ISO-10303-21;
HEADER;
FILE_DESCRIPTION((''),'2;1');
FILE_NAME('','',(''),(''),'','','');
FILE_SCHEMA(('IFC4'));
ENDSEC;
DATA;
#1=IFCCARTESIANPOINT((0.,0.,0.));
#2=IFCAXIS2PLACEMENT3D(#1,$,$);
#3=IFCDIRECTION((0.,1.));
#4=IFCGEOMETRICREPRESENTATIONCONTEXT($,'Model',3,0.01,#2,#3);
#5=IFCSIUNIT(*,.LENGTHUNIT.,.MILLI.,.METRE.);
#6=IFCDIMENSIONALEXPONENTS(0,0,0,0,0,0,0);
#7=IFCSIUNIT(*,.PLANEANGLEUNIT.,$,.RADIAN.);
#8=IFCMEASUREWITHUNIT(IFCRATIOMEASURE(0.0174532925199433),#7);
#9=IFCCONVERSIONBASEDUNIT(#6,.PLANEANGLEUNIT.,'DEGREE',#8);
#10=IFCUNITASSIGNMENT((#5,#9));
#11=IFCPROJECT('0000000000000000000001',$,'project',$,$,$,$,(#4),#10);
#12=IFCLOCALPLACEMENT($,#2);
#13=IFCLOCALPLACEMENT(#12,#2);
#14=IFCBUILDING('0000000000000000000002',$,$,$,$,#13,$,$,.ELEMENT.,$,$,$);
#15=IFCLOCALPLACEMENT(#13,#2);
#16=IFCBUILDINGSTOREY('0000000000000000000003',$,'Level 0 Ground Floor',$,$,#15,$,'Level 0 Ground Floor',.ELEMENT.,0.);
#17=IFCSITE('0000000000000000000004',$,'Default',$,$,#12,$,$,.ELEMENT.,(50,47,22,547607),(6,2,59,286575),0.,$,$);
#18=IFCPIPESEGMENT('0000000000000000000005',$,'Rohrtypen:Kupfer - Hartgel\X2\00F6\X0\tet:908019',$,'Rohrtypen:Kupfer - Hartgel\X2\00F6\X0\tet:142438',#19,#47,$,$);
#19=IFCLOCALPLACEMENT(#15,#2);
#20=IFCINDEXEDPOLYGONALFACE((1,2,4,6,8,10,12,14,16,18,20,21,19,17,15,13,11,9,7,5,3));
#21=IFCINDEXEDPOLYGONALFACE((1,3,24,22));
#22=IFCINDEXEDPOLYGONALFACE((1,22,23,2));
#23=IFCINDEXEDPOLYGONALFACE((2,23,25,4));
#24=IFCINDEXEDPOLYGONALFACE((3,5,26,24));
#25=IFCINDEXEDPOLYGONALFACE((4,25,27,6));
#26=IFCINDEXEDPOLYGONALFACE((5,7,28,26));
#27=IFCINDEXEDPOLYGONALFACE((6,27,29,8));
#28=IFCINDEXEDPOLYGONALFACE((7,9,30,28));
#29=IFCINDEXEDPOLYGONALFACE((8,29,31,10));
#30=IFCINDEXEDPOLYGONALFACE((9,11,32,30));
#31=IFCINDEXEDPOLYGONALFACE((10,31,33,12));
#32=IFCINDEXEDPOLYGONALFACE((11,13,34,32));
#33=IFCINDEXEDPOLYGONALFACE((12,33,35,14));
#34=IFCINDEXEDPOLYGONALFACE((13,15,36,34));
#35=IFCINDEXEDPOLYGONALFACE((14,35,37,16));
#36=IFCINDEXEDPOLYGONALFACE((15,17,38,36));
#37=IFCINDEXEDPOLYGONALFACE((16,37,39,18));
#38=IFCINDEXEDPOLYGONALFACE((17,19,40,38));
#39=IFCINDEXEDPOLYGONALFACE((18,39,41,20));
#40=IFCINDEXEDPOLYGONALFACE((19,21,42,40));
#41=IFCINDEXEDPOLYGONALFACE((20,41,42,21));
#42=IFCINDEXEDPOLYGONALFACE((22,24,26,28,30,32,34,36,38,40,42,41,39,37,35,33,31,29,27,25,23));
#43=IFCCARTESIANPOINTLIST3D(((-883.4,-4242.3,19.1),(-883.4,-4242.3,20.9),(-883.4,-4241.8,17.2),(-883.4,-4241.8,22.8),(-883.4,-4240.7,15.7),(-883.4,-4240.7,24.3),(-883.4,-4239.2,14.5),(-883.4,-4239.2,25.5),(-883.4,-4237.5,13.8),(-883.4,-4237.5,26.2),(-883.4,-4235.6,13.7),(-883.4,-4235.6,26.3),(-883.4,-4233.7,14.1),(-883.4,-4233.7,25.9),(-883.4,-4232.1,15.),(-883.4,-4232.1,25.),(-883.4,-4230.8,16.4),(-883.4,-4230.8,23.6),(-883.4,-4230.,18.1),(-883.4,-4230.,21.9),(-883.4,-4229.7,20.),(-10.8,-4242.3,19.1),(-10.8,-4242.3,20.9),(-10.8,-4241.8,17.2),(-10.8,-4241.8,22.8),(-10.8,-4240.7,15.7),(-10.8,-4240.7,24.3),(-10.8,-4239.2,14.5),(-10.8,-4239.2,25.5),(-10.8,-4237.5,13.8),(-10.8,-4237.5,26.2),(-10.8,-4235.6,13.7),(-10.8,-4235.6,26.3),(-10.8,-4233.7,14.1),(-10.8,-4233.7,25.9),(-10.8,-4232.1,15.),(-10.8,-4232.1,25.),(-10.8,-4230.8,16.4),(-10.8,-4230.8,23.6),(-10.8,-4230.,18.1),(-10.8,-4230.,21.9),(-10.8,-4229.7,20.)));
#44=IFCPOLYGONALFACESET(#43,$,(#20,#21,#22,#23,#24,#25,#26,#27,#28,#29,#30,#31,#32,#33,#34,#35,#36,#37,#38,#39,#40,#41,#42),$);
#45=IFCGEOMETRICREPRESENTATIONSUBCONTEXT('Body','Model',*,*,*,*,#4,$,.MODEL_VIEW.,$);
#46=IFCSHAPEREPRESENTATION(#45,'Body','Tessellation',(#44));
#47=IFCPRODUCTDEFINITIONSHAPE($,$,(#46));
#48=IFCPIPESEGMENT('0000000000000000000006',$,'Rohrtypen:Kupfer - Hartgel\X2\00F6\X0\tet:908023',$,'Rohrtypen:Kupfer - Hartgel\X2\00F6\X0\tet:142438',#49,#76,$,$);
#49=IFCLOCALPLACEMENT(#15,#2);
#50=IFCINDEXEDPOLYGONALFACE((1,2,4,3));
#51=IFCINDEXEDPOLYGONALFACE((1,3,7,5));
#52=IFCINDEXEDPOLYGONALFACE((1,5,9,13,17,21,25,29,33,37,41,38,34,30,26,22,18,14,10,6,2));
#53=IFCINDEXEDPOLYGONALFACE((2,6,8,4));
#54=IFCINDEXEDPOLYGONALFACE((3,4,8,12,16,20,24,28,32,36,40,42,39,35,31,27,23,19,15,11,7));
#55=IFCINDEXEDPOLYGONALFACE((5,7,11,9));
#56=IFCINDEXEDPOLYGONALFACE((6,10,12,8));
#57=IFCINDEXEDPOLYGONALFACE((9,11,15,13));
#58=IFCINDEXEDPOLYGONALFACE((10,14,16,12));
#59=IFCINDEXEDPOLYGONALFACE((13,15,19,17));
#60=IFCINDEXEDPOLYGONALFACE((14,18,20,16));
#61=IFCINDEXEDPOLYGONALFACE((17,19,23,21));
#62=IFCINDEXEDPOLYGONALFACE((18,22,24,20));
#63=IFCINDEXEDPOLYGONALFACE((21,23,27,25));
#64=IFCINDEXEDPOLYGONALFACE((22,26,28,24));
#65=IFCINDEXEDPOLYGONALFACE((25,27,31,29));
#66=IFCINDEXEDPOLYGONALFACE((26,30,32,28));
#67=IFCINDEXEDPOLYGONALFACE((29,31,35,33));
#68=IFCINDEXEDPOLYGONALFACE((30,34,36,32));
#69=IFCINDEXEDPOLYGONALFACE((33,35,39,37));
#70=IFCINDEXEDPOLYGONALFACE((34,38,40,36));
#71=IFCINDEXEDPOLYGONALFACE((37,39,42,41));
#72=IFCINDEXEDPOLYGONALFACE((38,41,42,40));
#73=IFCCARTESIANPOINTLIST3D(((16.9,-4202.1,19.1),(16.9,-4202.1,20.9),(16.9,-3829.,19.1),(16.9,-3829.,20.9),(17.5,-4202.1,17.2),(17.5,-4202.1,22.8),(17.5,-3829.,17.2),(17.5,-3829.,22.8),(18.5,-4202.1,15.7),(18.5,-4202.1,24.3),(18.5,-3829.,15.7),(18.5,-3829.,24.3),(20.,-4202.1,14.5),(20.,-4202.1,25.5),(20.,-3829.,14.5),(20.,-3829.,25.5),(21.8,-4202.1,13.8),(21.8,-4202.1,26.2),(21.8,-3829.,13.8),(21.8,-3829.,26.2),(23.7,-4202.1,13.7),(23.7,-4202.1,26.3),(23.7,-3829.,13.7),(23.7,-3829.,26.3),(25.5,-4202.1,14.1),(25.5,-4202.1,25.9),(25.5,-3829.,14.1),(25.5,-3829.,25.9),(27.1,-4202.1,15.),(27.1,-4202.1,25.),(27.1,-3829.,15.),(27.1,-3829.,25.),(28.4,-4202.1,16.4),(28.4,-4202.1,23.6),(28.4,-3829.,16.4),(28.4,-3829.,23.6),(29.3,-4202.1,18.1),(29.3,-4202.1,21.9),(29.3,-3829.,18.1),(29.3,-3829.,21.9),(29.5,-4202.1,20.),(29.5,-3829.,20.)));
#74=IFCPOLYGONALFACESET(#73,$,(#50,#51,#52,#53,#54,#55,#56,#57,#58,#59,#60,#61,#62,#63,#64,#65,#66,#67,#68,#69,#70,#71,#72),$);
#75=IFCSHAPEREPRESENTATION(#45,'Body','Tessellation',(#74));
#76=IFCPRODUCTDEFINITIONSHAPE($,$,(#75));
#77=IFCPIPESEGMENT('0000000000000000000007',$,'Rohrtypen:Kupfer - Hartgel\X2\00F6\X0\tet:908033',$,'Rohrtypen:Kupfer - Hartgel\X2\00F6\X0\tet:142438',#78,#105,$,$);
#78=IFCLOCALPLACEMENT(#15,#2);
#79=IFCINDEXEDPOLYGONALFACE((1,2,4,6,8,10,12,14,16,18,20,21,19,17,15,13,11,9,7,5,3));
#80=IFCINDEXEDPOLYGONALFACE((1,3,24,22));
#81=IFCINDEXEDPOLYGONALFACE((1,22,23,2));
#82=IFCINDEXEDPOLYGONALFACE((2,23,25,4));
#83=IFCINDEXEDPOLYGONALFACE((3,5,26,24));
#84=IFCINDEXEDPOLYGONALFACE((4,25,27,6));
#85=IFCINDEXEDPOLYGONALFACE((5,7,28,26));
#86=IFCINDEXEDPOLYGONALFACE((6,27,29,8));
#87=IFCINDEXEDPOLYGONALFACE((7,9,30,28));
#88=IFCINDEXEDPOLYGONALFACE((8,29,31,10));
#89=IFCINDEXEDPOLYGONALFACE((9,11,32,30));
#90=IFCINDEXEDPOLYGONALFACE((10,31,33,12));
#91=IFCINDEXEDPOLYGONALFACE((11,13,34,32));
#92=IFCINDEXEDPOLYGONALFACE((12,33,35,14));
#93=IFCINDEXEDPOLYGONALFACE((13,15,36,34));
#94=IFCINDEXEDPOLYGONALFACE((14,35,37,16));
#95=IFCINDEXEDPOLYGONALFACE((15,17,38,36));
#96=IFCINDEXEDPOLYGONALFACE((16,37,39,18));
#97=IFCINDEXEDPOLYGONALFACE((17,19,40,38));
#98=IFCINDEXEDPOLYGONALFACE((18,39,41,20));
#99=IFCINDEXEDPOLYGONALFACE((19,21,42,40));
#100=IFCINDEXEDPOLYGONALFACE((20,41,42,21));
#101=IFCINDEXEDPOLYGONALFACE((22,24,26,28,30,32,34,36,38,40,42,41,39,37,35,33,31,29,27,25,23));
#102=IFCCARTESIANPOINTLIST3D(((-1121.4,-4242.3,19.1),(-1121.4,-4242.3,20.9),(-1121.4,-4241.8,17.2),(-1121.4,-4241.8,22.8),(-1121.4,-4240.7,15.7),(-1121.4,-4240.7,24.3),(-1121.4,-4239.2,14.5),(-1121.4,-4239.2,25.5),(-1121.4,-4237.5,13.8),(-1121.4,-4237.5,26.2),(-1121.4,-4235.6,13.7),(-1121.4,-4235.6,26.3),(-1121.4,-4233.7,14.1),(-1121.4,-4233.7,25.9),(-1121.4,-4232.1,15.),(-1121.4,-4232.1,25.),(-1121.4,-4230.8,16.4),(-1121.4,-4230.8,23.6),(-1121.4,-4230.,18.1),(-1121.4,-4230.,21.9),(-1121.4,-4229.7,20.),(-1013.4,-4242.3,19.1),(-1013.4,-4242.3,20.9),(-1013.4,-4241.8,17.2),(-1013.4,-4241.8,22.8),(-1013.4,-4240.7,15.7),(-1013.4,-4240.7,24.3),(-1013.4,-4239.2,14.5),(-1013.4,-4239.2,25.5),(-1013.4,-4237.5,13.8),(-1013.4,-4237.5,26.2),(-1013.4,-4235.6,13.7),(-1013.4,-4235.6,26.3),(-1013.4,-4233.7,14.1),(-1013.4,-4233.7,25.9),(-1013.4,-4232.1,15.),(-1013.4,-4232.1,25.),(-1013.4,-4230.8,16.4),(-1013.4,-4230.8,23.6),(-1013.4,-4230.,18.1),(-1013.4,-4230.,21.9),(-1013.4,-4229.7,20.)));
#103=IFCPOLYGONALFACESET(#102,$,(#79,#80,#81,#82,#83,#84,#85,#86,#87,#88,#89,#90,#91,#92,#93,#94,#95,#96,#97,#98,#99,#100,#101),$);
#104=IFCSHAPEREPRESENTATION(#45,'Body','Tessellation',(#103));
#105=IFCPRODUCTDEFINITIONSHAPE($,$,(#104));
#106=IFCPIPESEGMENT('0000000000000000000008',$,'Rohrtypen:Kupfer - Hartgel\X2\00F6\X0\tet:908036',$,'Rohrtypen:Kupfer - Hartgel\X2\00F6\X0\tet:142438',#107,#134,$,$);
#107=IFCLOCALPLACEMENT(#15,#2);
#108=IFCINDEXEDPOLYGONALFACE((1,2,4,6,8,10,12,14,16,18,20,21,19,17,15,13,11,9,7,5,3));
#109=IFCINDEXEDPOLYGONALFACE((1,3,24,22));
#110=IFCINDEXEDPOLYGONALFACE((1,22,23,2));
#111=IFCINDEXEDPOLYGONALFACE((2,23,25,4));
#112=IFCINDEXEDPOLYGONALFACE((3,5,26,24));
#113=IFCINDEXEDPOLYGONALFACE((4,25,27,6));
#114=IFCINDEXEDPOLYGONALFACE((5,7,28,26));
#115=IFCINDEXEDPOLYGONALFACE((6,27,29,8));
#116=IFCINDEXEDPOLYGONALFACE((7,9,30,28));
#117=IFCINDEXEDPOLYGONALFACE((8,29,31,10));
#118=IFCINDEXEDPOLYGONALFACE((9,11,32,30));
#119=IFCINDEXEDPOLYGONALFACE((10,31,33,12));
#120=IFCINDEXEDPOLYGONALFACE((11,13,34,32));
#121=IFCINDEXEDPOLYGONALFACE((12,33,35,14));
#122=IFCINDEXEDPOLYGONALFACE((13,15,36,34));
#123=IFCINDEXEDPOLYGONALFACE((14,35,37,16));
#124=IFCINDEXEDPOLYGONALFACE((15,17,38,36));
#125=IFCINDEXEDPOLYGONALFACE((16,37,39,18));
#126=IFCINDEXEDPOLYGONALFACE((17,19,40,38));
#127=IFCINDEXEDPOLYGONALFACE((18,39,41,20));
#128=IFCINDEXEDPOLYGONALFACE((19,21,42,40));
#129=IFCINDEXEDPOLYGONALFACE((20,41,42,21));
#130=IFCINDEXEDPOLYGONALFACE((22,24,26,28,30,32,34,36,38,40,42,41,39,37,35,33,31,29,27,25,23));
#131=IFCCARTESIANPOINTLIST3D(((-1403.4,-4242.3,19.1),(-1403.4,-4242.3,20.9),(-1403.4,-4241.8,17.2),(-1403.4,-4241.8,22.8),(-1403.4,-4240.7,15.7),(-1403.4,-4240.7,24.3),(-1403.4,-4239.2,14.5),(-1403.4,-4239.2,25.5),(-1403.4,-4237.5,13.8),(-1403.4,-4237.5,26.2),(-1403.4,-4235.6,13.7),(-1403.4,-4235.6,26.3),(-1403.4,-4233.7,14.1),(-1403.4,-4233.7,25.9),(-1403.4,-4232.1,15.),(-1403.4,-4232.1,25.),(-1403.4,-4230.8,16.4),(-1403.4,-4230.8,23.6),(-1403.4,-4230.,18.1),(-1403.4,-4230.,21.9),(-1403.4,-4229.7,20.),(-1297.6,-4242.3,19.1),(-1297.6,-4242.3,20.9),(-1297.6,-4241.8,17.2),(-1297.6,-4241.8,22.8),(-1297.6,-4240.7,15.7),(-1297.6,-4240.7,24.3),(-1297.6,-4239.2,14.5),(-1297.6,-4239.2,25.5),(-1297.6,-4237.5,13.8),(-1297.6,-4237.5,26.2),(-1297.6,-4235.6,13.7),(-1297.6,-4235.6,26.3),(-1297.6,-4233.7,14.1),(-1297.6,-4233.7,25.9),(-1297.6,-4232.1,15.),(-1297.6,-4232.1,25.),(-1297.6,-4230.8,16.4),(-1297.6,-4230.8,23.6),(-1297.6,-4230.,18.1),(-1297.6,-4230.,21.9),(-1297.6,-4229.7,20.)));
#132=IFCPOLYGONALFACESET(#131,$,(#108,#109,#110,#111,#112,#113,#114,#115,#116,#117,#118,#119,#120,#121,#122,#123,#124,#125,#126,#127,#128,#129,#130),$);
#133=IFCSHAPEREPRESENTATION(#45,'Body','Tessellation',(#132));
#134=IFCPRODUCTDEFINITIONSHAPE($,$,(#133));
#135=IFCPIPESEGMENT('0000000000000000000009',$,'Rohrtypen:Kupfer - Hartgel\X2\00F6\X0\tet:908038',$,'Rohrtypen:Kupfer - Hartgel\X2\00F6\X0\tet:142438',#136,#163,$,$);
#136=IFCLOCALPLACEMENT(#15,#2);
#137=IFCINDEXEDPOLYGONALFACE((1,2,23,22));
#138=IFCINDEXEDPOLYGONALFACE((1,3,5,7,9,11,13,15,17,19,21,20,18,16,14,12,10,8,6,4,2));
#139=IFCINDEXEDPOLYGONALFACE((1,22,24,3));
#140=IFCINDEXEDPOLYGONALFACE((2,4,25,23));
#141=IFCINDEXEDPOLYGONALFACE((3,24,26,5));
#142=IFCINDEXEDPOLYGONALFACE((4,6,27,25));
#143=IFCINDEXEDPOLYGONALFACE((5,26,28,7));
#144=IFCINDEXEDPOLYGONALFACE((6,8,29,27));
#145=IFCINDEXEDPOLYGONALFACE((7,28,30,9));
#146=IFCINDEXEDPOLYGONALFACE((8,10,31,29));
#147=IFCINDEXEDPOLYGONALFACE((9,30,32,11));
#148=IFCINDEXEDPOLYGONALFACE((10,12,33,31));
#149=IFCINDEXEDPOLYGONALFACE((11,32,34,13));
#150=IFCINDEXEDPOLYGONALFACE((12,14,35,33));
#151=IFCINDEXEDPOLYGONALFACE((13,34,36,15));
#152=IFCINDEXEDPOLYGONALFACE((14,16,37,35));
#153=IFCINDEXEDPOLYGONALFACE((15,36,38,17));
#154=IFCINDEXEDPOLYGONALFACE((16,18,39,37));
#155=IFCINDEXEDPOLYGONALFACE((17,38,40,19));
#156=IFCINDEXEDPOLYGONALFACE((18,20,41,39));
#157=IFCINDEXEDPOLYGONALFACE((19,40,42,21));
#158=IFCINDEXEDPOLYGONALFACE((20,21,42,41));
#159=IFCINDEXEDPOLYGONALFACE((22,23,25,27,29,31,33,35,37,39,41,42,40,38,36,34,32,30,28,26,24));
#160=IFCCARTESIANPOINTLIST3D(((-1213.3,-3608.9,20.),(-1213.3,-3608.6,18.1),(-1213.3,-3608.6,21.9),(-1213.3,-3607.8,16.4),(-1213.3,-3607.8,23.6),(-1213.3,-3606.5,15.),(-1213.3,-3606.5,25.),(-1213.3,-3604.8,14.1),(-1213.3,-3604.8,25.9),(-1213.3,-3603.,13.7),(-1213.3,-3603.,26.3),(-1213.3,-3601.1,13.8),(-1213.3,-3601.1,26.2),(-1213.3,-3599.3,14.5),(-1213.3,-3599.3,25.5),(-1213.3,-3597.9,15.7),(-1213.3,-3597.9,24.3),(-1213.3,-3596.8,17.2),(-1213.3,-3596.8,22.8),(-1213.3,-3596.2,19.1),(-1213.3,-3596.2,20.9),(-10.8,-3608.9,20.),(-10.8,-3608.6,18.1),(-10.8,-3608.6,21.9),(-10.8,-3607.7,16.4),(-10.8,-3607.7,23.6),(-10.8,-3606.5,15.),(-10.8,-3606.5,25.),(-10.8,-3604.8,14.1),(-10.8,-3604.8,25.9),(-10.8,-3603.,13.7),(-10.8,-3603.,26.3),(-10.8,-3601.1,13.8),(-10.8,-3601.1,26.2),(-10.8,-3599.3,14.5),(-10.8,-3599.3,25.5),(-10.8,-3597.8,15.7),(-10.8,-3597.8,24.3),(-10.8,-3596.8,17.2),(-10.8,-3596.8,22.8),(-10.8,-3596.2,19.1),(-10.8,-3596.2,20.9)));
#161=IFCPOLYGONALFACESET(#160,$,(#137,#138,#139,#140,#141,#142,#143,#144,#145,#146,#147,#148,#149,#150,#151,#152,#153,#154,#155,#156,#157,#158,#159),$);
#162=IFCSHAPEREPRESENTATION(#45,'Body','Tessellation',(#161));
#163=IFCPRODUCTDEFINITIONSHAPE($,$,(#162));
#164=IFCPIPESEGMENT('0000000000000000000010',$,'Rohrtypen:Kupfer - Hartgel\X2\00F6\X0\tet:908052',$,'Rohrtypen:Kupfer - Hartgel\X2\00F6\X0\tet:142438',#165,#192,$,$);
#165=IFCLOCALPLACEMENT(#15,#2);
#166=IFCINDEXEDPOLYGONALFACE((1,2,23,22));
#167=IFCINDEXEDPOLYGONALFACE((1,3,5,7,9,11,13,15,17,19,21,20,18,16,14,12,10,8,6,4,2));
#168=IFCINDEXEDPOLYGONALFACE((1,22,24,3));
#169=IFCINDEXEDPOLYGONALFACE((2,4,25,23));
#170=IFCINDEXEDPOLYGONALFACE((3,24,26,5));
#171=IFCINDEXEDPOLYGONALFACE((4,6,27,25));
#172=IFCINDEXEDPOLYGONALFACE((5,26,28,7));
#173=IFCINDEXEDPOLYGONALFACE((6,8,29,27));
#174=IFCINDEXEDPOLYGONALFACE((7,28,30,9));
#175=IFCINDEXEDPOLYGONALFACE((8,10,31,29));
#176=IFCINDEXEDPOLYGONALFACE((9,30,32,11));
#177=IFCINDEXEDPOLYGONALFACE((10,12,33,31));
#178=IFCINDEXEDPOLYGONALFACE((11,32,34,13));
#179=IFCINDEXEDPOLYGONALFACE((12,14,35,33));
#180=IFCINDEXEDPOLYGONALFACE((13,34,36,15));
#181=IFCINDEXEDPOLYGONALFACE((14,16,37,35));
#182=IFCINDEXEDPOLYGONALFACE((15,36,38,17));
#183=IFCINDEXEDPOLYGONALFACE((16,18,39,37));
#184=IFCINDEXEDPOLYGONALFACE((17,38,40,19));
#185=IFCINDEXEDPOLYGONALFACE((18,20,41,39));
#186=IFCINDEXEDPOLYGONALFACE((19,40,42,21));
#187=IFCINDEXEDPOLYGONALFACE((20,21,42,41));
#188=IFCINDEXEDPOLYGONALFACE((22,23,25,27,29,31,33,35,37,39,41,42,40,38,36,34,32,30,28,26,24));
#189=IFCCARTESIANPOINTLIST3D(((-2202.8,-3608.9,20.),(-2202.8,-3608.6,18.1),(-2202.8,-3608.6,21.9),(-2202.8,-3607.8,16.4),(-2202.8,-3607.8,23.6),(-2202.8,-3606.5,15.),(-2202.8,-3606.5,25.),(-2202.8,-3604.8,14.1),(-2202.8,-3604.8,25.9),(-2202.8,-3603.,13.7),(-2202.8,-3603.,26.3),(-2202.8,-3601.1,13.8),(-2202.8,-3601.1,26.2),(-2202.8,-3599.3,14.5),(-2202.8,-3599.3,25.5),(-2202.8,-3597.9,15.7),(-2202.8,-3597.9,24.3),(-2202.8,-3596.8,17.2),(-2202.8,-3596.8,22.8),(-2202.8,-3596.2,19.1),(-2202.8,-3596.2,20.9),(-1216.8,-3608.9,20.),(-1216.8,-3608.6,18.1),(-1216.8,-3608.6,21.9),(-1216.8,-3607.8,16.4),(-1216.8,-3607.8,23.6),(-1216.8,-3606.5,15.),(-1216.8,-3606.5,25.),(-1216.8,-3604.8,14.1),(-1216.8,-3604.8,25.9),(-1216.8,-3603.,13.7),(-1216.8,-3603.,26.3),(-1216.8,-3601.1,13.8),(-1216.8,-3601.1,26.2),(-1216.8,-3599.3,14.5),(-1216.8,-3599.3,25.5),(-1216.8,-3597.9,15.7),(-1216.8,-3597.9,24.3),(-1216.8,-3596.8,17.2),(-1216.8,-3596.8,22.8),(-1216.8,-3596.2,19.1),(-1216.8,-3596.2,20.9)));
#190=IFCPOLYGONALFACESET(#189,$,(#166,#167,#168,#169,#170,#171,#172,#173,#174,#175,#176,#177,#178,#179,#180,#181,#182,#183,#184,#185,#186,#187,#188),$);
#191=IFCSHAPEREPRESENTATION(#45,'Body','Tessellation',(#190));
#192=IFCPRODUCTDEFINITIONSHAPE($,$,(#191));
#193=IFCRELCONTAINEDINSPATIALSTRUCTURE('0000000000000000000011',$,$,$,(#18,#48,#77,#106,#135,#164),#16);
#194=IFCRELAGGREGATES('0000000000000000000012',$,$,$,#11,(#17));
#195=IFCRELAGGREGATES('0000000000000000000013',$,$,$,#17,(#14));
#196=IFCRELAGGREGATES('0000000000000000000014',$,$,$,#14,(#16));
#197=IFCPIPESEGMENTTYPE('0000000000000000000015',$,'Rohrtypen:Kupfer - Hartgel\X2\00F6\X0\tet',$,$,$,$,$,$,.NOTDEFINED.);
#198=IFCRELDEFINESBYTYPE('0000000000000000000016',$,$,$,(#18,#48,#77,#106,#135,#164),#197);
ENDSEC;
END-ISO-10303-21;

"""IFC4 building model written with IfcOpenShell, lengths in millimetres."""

from ifc_helpers import new_model, entity, si_unit, converted_unit, direction, frame, frame_2d, origin, place, context, subcontext, project, spatial, circle, extrude, type_object, element, save


model = new_model("IFC4")

# Units and contexts
model_context = context("Model", 3, precision=0.01, world=origin(), true_north=direction((0.0, 1.0)))
body_context = subcontext(model_context, "Body", "Model", "MODEL_VIEW")
ifc_project = project(units=[si_unit("LENGTHUNIT", "METRE", prefix="MILLI"), converted_unit("PLANEANGLEUNIT", "DEGREE", entity("IfcRatioMeasure", 0.0174532925199433), si_unit("PLANEANGLEUNIT", "RADIAN"), dimensions=[0, 0, 0, 0, 0, 0, 0])], contexts=[model_context])

# Site, building, storey
site_placement = place(None, origin())
site = spatial("IfcSite", under=ifc_project, at=site_placement, Name="Default", CompositionType="ELEMENT", RefLatitude=(50, 47, 22, 547607), RefLongitude=(6, 2, 59, 286575), RefElevation=0.0)
building_placement = place(site_placement, origin())
building = spatial("IfcBuilding", under=site, at=building_placement, CompositionType="ELEMENT")
storey_placement = place(building_placement, origin())
storey = spatial("IfcBuildingStorey", under=building, at=storey_placement, Name="Level 0 Ground Floor", LongName="Level 0 Ground Floor", CompositionType="ELEMENT", Elevation=0.0)

# Pipe segments
pipe_segment_type = type_object("IfcPipeSegmentType", Name="Rohrtypen:Kupfer - Hartgelötet", PredefinedType="NOTDEFINED")
pipe_segment_1_placement = place(storey_placement, frame((-883.4, -4244.0, 12.1)))
element("IfcPipeSegment", 1, at=pipe_segment_1_placement, inside=storey, type_object=pipe_segment_type, Name="Rohrtypen:Kupfer - Hartgelötet:908019", ObjectType="Rohrtypen:Kupfer - Hartgelötet:142438", context=body_context, shape_type="SweptSolid", body=[
    extrude(circle(Radius=6.3, at=frame_2d((0.0, 0.0), x_axis=(1.0, 0.0))), frame((0.0, 7.9, 7.9), z_axis=(1.0, 0.0, 0.0), x_axis=(0.0, 1.0, 0.0)), (0.0, 0.0, 1.0), 872.6),
])
pipe_segment_2_placement = place(storey_placement, frame((15.2, -4202.1, 12.1)))
element("IfcPipeSegment", 2, at=pipe_segment_2_placement, inside=storey, type_object=pipe_segment_type, Name="Rohrtypen:Kupfer - Hartgelötet:908023", ObjectType="Rohrtypen:Kupfer - Hartgelötet:142438", context=body_context, shape_type="SweptSolid", body=[
    extrude(circle(Radius=6.3, at=frame_2d((0.0, 0.0), x_axis=(1.0, 0.0))), frame((7.9, 0.0, 7.9), z_axis=(0.0, 1.0, 0.0), x_axis=(1.0, 0.0, 0.0)), (0.0, 0.0, 1.0), 373.1),
])
pipe_segment_3_placement = place(storey_placement, frame((-1121.4, -4244.0, 12.1)))
element("IfcPipeSegment", 3, at=pipe_segment_3_placement, inside=storey, type_object=pipe_segment_type, Name="Rohrtypen:Kupfer - Hartgelötet:908033", ObjectType="Rohrtypen:Kupfer - Hartgelötet:142438", context=body_context, shape_type="SweptSolid", body=[
    extrude(circle(Radius=6.3, at=frame_2d((0.0, 0.0), x_axis=(1.0, 0.0))), frame((0.0, 7.9, 7.9), z_axis=(1.0, 0.0, 0.0), x_axis=(0.0, 1.0, 0.0)), (0.0, 0.0, 1.0), 108.0),
])
pipe_segment_4_placement = place(storey_placement, frame((-1403.4, -4244.0, 12.1)))
element("IfcPipeSegment", 4, at=pipe_segment_4_placement, inside=storey, type_object=pipe_segment_type, Name="Rohrtypen:Kupfer - Hartgelötet:908036", ObjectType="Rohrtypen:Kupfer - Hartgelötet:142438", context=body_context, shape_type="SweptSolid", body=[
    extrude(circle(Radius=6.3, at=frame_2d((0.0, 0.0), x_axis=(1.0, 0.0))), frame((0.0, 7.9, 7.9), z_axis=(1.0, 0.0, 0.0), x_axis=(0.0, 1.0, 0.0)), (0.0, 0.0, 1.0), 105.8),
])
pipe_segment_5_placement = place(storey_placement, frame((-1213.3, -3610.5, 12.1)))
element("IfcPipeSegment", 5, at=pipe_segment_5_placement, inside=storey, type_object=pipe_segment_type, Name="Rohrtypen:Kupfer - Hartgelötet:908038", ObjectType="Rohrtypen:Kupfer - Hartgelötet:142438", context=body_context, shape_type="SweptSolid", body=[
    extrude(circle(Radius=6.3, at=frame_2d((0.0, 0.0), x_axis=(1.0, 0.0))), frame((0.0, 7.9, 7.9), z_axis=(1.0, 0.000017, 0.0), x_axis=(0.000017, -1.0, 0.0)), (0.0, 0.0, 1.0), 1202.5),
])
pipe_segment_6_placement = place(storey_placement, frame((-2202.8, -3610.5, 12.1)))
element("IfcPipeSegment", 6, at=pipe_segment_6_placement, inside=storey, type_object=pipe_segment_type, Name="Rohrtypen:Kupfer - Hartgelötet:908052", ObjectType="Rohrtypen:Kupfer - Hartgelötet:142438", context=body_context, shape_type="SweptSolid", body=[
    extrude(circle(Radius=6.3, at=frame_2d((0.0, 0.0), x_axis=(1.0, 0.0))), frame((0.0, 7.9, 7.9), z_axis=(1.0, 0.0, 0.0), x_axis=(0.0, -1.0, 0.0)), (0.0, 0.0, 1.0), 986.0),
])

save(model, "model.ifc")
